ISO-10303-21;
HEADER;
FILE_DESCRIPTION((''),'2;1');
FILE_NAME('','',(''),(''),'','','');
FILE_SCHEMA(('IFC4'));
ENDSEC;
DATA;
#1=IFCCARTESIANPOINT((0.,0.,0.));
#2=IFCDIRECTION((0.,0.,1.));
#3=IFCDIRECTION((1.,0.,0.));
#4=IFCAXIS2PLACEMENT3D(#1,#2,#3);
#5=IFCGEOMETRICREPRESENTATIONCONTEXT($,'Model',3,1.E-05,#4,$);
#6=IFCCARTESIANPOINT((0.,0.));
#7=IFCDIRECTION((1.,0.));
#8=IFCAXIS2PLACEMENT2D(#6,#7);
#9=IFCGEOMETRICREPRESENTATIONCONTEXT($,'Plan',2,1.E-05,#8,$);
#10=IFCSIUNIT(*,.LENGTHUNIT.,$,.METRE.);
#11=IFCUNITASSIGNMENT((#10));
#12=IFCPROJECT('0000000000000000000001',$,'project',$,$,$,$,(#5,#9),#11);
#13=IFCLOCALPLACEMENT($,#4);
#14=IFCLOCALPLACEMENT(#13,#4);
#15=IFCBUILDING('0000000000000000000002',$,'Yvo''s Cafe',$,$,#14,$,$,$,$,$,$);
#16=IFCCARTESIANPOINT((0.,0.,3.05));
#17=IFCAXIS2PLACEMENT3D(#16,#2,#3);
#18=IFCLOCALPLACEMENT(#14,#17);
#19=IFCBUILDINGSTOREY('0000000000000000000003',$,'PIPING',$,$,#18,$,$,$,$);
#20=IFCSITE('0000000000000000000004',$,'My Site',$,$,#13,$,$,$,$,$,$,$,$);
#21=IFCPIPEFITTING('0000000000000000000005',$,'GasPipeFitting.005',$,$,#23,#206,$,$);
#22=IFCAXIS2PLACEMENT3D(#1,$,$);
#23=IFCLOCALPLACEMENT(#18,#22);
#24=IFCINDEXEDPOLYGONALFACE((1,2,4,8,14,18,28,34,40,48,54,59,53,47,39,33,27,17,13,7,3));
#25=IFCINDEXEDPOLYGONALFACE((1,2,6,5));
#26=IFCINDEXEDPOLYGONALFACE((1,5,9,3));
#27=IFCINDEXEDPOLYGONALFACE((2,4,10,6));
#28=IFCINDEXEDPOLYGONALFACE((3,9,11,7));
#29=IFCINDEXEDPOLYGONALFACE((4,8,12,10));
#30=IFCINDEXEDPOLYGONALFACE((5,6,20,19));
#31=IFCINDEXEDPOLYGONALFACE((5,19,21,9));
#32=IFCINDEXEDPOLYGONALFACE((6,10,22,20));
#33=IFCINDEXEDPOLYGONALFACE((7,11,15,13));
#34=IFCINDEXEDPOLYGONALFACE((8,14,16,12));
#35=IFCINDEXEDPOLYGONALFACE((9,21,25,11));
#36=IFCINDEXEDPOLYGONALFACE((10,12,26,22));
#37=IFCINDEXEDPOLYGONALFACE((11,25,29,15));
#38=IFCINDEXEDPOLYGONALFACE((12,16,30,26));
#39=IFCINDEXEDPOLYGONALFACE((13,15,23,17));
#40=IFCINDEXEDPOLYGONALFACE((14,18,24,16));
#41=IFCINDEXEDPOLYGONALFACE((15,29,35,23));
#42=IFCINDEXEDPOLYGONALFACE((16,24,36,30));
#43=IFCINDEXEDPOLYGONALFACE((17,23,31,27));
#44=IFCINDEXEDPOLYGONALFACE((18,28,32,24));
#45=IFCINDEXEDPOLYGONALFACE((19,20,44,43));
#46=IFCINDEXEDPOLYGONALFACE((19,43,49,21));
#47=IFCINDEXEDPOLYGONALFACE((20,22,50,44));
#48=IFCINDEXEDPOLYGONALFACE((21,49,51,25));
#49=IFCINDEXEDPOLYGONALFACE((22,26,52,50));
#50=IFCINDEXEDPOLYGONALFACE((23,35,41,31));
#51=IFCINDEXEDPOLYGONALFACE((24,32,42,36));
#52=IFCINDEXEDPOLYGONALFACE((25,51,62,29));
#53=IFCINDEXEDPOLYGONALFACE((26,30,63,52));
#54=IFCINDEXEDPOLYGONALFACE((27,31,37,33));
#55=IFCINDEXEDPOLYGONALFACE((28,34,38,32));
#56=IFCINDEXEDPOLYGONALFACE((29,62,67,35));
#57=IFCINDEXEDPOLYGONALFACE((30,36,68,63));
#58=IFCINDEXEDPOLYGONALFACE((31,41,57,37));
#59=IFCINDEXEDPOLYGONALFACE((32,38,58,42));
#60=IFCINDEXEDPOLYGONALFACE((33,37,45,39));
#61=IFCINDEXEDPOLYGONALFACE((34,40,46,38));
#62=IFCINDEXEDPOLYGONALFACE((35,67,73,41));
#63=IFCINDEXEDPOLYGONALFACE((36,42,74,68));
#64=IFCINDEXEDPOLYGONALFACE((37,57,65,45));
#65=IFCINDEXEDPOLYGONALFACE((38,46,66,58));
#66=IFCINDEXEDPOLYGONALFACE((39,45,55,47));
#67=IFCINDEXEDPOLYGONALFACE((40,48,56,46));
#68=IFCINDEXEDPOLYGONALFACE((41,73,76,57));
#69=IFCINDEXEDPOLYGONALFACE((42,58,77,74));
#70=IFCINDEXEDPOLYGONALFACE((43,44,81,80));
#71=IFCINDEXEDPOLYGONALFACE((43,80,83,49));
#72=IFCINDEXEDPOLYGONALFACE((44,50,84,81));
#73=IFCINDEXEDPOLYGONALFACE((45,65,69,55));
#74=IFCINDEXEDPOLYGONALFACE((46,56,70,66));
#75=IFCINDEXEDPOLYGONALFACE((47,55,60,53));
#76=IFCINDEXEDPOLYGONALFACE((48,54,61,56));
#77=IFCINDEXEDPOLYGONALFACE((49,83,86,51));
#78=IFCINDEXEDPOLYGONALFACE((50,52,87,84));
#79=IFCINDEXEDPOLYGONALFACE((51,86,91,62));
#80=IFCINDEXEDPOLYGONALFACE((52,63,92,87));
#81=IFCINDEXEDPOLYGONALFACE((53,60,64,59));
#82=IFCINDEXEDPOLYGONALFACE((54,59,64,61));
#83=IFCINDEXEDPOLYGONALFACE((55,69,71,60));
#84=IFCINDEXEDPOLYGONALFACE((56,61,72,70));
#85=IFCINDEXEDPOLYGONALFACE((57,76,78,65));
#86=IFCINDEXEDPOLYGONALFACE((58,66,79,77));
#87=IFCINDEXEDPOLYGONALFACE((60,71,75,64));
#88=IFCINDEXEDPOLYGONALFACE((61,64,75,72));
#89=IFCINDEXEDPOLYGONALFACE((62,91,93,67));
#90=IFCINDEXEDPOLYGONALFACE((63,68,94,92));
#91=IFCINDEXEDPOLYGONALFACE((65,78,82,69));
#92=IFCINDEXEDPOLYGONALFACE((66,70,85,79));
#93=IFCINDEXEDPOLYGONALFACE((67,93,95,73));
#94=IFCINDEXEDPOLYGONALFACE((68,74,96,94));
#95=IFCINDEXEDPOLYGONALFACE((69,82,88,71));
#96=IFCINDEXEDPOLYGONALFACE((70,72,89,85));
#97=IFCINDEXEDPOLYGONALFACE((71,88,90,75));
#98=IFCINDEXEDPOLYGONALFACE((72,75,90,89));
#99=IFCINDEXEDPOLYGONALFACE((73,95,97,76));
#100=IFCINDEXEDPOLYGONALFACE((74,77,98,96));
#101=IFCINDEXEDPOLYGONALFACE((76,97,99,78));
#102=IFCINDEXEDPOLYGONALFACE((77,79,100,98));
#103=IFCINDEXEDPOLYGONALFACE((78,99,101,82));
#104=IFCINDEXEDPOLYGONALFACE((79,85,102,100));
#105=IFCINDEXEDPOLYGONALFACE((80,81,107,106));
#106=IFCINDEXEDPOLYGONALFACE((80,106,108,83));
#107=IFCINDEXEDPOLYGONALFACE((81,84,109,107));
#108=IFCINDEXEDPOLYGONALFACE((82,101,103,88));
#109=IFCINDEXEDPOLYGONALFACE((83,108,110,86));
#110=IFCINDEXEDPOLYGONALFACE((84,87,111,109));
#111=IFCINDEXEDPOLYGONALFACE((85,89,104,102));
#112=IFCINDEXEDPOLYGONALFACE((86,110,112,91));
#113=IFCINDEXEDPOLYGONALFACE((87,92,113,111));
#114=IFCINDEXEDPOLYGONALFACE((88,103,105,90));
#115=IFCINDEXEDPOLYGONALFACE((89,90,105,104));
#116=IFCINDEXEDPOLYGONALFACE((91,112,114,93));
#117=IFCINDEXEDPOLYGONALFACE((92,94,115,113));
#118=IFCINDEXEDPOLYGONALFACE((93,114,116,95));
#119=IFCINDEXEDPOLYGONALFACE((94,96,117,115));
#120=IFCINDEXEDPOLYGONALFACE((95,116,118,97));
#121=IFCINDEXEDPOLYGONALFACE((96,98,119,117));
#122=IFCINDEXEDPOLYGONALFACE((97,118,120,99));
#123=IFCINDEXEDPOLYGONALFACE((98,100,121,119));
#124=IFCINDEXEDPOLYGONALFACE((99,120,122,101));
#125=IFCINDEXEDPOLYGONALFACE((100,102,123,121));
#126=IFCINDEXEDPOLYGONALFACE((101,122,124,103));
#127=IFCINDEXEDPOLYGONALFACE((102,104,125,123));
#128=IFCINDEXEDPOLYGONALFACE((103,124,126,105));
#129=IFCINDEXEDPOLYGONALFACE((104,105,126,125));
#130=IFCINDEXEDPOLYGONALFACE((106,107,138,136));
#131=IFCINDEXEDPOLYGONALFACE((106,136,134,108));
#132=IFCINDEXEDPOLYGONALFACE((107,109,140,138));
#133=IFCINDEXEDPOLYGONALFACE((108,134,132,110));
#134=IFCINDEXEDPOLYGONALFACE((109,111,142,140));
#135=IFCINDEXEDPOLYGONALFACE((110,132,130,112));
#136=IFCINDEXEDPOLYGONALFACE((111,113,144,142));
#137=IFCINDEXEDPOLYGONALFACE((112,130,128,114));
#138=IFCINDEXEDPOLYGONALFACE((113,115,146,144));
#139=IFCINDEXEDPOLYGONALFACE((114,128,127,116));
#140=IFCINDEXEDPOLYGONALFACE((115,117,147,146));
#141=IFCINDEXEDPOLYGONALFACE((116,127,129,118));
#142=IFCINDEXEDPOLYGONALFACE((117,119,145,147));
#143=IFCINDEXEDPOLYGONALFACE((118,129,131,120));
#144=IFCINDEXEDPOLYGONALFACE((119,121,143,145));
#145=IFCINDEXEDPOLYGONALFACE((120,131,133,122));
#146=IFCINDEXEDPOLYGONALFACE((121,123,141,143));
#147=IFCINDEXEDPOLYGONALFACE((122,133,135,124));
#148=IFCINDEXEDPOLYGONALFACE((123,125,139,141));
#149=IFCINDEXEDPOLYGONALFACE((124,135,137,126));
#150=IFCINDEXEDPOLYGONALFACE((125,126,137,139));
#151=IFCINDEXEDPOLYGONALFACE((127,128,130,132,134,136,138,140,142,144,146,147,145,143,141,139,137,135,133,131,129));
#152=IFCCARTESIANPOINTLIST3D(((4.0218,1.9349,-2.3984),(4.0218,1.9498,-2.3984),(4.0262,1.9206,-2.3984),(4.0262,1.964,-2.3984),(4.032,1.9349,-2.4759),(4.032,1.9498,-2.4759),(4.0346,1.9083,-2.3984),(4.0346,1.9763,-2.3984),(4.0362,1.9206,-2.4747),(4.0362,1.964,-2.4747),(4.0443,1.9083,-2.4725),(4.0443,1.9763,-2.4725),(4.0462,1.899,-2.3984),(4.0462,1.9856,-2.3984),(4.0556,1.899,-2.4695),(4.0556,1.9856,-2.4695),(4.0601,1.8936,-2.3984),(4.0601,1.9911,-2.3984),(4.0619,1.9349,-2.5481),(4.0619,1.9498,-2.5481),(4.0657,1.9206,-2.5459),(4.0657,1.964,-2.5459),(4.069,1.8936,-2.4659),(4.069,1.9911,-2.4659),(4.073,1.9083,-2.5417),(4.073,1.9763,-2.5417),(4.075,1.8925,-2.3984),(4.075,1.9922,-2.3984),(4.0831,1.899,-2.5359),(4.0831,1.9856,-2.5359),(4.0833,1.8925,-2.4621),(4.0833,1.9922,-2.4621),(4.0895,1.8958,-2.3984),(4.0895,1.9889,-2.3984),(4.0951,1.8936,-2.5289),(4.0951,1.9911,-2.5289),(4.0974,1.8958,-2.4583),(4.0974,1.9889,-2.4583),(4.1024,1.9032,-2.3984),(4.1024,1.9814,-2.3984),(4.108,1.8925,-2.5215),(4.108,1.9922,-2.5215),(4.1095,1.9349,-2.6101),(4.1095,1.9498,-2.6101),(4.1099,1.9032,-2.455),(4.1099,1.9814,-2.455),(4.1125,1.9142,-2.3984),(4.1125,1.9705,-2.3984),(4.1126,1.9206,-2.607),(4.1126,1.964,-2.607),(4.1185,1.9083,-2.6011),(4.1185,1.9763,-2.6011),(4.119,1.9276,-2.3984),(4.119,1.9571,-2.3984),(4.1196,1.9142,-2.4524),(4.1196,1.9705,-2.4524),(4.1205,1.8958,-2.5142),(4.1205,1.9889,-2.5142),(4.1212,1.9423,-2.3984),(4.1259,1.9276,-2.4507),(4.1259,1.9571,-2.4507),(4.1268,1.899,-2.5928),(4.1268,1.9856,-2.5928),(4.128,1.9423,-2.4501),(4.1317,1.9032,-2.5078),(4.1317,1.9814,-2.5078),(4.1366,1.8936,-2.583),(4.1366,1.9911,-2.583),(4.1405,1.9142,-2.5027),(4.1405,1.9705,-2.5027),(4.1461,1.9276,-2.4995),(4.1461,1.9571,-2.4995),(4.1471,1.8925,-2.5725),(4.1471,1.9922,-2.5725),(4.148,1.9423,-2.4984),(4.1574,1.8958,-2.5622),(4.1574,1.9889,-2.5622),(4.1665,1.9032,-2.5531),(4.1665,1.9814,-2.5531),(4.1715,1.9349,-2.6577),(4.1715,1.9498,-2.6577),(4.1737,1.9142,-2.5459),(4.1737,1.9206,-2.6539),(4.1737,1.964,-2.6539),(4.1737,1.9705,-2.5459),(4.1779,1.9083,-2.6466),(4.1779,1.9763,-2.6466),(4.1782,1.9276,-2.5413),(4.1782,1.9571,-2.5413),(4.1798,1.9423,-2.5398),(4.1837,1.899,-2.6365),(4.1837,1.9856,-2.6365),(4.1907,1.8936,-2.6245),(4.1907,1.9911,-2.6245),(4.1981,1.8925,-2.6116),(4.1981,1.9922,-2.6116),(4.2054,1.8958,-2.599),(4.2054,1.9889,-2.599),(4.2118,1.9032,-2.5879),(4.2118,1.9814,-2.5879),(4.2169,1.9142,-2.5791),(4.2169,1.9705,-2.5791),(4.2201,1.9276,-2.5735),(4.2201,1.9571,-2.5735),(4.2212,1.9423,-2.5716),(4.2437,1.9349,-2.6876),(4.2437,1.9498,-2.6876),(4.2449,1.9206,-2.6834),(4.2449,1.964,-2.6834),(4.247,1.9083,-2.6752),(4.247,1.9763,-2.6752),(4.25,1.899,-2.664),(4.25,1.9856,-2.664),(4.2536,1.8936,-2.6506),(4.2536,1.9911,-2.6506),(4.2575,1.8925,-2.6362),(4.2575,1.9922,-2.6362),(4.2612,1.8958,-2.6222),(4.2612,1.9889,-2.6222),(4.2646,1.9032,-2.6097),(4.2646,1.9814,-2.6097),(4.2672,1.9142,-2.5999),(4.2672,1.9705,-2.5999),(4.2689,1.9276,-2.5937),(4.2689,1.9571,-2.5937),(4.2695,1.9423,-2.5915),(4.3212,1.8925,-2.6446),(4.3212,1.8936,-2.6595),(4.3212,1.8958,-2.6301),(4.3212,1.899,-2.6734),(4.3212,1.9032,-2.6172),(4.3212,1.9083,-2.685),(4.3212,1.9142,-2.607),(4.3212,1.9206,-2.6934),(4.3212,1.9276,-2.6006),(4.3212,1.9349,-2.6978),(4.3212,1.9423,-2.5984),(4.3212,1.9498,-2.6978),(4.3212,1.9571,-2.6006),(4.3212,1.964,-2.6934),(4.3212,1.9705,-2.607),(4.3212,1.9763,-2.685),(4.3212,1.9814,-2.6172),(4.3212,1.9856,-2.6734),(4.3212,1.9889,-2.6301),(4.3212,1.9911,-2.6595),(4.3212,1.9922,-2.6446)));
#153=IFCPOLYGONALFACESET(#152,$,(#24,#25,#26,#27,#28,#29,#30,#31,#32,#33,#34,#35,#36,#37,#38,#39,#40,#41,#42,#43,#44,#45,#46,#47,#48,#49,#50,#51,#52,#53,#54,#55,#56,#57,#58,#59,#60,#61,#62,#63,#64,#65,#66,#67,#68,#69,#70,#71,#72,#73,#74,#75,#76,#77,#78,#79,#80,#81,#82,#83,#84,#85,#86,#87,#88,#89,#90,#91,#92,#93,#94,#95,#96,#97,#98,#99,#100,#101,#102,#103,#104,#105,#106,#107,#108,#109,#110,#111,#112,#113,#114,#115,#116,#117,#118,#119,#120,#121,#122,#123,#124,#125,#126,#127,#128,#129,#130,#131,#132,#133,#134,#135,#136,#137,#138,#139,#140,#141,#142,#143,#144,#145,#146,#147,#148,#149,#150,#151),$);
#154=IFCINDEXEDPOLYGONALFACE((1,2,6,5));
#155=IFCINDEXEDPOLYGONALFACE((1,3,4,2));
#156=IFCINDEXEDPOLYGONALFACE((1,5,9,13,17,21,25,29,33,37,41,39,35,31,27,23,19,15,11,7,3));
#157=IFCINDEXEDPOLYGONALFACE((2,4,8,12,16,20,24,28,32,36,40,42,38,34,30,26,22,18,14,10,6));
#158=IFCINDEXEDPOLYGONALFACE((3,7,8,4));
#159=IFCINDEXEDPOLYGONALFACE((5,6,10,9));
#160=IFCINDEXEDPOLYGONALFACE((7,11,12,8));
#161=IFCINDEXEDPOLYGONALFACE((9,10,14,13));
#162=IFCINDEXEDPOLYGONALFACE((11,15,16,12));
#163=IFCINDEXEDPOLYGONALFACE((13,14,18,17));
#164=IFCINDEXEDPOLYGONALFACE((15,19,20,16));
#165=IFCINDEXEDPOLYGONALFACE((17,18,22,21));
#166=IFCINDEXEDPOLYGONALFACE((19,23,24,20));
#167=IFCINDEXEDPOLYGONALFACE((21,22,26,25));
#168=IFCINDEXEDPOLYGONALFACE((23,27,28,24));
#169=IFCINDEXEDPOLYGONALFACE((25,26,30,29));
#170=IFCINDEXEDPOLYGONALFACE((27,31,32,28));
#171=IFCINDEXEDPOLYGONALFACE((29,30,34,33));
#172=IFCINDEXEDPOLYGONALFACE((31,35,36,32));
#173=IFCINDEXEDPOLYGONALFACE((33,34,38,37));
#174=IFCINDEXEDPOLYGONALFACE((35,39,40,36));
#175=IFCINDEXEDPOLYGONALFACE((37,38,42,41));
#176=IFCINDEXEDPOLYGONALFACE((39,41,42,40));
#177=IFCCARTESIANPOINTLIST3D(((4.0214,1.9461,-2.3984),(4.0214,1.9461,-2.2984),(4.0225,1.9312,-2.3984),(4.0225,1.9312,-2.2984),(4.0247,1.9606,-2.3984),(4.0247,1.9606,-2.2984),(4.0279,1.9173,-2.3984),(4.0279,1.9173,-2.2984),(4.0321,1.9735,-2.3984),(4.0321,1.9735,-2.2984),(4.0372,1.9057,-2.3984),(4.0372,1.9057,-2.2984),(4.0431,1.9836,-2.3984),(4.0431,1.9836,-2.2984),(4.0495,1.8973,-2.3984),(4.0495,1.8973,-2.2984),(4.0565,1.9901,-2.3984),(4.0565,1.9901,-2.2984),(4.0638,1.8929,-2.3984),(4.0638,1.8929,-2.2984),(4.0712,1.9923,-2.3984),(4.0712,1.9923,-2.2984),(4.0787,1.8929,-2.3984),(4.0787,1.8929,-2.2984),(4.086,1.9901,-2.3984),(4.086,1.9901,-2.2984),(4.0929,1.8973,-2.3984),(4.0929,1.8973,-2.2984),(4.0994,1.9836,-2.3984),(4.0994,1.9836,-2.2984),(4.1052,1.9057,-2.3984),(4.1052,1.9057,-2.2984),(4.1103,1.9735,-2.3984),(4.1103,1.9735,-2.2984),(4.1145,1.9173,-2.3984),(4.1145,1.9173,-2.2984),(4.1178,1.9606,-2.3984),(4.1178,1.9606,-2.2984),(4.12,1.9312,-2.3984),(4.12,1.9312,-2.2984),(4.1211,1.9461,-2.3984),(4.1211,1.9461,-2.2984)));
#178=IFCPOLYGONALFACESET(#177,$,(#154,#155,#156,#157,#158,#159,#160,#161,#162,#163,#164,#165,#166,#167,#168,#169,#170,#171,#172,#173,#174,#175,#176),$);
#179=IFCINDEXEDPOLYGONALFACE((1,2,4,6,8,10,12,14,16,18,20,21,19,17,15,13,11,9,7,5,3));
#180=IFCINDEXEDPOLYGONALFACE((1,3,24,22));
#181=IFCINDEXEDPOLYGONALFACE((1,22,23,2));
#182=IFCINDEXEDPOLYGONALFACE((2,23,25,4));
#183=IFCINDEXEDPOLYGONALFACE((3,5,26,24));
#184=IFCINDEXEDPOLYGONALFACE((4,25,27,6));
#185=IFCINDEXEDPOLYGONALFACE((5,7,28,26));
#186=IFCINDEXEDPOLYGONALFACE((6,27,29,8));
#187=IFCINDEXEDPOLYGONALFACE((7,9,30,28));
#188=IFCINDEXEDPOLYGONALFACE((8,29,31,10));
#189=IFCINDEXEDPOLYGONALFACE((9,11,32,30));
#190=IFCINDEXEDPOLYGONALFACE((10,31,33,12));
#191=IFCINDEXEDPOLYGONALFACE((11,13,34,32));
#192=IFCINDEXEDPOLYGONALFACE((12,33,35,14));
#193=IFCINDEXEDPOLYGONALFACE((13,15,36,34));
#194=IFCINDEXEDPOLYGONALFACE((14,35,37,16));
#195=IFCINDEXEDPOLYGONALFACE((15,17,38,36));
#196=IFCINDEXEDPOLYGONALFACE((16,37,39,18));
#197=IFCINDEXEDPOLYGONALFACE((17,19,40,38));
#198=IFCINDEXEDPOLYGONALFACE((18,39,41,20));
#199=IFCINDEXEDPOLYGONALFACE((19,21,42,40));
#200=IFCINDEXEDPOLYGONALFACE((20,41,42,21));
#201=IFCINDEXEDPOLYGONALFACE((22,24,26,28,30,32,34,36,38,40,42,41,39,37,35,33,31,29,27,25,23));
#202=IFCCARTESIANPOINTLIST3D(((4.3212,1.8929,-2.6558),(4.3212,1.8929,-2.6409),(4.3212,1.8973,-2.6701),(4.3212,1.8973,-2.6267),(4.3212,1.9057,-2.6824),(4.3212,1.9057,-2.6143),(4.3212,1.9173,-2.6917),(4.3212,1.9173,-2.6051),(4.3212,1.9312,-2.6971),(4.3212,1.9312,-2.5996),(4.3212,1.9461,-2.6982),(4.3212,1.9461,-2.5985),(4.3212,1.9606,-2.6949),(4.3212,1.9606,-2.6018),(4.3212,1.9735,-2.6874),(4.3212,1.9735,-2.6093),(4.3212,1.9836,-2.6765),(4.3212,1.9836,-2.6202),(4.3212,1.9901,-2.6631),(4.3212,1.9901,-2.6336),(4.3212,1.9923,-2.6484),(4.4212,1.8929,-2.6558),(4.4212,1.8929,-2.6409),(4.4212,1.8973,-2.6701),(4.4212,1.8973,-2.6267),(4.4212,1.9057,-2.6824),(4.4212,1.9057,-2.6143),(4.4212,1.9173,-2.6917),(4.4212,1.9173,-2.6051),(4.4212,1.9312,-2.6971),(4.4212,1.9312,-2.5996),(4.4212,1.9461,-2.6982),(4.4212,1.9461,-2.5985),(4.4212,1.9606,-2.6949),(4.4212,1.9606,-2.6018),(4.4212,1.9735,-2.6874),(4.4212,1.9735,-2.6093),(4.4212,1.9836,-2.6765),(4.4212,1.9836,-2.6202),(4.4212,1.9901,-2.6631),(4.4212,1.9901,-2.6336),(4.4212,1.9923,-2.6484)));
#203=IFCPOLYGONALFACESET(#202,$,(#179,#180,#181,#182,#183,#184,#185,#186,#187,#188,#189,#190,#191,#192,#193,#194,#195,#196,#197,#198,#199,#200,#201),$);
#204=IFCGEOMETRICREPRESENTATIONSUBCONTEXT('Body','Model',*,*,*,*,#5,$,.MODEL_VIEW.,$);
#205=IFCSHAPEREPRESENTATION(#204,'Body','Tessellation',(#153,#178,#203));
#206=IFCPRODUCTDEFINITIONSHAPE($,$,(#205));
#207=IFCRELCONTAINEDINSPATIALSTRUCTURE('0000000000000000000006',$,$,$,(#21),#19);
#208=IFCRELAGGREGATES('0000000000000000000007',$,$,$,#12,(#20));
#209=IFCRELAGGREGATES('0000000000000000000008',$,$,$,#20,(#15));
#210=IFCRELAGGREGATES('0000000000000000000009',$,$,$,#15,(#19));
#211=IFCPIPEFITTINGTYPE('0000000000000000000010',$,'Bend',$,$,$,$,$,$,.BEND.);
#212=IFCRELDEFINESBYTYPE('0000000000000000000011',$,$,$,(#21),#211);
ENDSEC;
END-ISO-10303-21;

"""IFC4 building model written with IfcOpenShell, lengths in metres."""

from ifc_helpers import new_model, entity, si_unit, frame, origin_with_axes, origin_2d_with_axis, place, context, subcontext, project, spatial, circle, extrude, source, transform, mapped, type_object, type_shapes, element, save


model = new_model("IFC4")

# Units and contexts
model_context = context("Model", 3, precision=1e-05, world=origin_with_axes())
plan_context = context("Plan", 2, precision=1e-05, world=origin_2d_with_axis())
body_context = subcontext(model_context, "Body", "Model", "MODEL_VIEW")
ifc_project = project(units=[si_unit("LENGTHUNIT", "METRE")], contexts=[model_context, plan_context])

# Site, building, storey
site_placement = place(None, origin_with_axes())
site = spatial("IfcSite", under=ifc_project, at=site_placement, Name="My Site")
building_placement = place(site_placement, origin_with_axes())
building = spatial("IfcBuilding", under=site, at=building_placement, Name="Yvo's Cafe")
storey_placement = place(building_placement, frame((0.0, 0.0, 3.05), z_axis=(0.0, 0.0, 1.0), x_axis=(1.0, 0.0, 0.0)))
storey = spatial("IfcBuildingStorey", under=building, at=storey_placement, Name="PIPING")

# Shared definitions
pipe_fitting_type_1 = type_object("IfcPipeFittingType", Name="Bend", PredefinedType="BEND")
shared_shape_1 = source(origin_with_axes(), body_context, "Body", "SolidModel", [
    entity("IfcSweptDiskSolid", entity("IfcIndexedPolyCurve", entity("IfcCartesianPointList3D", [[0.0, 0.0, -0.1], [0.0, -0.0732, -0.2768], [0.0, -0.25, -0.35]]), [entity("IfcArcIndex", [1, 2, 3])]), 0.05),
    extrude(circle(Radius=0.05), origin_with_axes(), (0.0, 0.0, -1.0), 0.1),
    extrude(circle(Radius=0.05), frame((0.0, -0.25, -0.35), z_axis=(0.0, -1.0, 0.0), x_axis=(1.0, 0.0, 0.0)), (0.0, 0.0, 1.0), 0.1),
])
type_shapes(pipe_fitting_type_1, [shared_shape_1])

# Pipe fitting
for number, where, z_axis, x_axis, name in (
    (1, (4.0712, 1.9423, -2.2984), (0.0, 0.0, 1.0), (0.0, 1.0, 0.0), "GasPipeFitting.005"),
):
    element("IfcPipeFitting", number, at=place(storey_placement, frame(where, z_axis=z_axis, x_axis=x_axis)), inside=storey, type_object=pipe_fitting_type_1, Name=name, context=body_context, shape_type="MappedRepresentation", body=[
        mapped(shared_shape_1, transform((0.0, 0.0, 0.0), x_axis=(1.0, 0.0, 0.0), y_axis=(0.0, 1.0, 0.0), z_axis=(0.0, 0.0, 1.0), scale=1.0)),
    ])

save(model, "model.ifc")
